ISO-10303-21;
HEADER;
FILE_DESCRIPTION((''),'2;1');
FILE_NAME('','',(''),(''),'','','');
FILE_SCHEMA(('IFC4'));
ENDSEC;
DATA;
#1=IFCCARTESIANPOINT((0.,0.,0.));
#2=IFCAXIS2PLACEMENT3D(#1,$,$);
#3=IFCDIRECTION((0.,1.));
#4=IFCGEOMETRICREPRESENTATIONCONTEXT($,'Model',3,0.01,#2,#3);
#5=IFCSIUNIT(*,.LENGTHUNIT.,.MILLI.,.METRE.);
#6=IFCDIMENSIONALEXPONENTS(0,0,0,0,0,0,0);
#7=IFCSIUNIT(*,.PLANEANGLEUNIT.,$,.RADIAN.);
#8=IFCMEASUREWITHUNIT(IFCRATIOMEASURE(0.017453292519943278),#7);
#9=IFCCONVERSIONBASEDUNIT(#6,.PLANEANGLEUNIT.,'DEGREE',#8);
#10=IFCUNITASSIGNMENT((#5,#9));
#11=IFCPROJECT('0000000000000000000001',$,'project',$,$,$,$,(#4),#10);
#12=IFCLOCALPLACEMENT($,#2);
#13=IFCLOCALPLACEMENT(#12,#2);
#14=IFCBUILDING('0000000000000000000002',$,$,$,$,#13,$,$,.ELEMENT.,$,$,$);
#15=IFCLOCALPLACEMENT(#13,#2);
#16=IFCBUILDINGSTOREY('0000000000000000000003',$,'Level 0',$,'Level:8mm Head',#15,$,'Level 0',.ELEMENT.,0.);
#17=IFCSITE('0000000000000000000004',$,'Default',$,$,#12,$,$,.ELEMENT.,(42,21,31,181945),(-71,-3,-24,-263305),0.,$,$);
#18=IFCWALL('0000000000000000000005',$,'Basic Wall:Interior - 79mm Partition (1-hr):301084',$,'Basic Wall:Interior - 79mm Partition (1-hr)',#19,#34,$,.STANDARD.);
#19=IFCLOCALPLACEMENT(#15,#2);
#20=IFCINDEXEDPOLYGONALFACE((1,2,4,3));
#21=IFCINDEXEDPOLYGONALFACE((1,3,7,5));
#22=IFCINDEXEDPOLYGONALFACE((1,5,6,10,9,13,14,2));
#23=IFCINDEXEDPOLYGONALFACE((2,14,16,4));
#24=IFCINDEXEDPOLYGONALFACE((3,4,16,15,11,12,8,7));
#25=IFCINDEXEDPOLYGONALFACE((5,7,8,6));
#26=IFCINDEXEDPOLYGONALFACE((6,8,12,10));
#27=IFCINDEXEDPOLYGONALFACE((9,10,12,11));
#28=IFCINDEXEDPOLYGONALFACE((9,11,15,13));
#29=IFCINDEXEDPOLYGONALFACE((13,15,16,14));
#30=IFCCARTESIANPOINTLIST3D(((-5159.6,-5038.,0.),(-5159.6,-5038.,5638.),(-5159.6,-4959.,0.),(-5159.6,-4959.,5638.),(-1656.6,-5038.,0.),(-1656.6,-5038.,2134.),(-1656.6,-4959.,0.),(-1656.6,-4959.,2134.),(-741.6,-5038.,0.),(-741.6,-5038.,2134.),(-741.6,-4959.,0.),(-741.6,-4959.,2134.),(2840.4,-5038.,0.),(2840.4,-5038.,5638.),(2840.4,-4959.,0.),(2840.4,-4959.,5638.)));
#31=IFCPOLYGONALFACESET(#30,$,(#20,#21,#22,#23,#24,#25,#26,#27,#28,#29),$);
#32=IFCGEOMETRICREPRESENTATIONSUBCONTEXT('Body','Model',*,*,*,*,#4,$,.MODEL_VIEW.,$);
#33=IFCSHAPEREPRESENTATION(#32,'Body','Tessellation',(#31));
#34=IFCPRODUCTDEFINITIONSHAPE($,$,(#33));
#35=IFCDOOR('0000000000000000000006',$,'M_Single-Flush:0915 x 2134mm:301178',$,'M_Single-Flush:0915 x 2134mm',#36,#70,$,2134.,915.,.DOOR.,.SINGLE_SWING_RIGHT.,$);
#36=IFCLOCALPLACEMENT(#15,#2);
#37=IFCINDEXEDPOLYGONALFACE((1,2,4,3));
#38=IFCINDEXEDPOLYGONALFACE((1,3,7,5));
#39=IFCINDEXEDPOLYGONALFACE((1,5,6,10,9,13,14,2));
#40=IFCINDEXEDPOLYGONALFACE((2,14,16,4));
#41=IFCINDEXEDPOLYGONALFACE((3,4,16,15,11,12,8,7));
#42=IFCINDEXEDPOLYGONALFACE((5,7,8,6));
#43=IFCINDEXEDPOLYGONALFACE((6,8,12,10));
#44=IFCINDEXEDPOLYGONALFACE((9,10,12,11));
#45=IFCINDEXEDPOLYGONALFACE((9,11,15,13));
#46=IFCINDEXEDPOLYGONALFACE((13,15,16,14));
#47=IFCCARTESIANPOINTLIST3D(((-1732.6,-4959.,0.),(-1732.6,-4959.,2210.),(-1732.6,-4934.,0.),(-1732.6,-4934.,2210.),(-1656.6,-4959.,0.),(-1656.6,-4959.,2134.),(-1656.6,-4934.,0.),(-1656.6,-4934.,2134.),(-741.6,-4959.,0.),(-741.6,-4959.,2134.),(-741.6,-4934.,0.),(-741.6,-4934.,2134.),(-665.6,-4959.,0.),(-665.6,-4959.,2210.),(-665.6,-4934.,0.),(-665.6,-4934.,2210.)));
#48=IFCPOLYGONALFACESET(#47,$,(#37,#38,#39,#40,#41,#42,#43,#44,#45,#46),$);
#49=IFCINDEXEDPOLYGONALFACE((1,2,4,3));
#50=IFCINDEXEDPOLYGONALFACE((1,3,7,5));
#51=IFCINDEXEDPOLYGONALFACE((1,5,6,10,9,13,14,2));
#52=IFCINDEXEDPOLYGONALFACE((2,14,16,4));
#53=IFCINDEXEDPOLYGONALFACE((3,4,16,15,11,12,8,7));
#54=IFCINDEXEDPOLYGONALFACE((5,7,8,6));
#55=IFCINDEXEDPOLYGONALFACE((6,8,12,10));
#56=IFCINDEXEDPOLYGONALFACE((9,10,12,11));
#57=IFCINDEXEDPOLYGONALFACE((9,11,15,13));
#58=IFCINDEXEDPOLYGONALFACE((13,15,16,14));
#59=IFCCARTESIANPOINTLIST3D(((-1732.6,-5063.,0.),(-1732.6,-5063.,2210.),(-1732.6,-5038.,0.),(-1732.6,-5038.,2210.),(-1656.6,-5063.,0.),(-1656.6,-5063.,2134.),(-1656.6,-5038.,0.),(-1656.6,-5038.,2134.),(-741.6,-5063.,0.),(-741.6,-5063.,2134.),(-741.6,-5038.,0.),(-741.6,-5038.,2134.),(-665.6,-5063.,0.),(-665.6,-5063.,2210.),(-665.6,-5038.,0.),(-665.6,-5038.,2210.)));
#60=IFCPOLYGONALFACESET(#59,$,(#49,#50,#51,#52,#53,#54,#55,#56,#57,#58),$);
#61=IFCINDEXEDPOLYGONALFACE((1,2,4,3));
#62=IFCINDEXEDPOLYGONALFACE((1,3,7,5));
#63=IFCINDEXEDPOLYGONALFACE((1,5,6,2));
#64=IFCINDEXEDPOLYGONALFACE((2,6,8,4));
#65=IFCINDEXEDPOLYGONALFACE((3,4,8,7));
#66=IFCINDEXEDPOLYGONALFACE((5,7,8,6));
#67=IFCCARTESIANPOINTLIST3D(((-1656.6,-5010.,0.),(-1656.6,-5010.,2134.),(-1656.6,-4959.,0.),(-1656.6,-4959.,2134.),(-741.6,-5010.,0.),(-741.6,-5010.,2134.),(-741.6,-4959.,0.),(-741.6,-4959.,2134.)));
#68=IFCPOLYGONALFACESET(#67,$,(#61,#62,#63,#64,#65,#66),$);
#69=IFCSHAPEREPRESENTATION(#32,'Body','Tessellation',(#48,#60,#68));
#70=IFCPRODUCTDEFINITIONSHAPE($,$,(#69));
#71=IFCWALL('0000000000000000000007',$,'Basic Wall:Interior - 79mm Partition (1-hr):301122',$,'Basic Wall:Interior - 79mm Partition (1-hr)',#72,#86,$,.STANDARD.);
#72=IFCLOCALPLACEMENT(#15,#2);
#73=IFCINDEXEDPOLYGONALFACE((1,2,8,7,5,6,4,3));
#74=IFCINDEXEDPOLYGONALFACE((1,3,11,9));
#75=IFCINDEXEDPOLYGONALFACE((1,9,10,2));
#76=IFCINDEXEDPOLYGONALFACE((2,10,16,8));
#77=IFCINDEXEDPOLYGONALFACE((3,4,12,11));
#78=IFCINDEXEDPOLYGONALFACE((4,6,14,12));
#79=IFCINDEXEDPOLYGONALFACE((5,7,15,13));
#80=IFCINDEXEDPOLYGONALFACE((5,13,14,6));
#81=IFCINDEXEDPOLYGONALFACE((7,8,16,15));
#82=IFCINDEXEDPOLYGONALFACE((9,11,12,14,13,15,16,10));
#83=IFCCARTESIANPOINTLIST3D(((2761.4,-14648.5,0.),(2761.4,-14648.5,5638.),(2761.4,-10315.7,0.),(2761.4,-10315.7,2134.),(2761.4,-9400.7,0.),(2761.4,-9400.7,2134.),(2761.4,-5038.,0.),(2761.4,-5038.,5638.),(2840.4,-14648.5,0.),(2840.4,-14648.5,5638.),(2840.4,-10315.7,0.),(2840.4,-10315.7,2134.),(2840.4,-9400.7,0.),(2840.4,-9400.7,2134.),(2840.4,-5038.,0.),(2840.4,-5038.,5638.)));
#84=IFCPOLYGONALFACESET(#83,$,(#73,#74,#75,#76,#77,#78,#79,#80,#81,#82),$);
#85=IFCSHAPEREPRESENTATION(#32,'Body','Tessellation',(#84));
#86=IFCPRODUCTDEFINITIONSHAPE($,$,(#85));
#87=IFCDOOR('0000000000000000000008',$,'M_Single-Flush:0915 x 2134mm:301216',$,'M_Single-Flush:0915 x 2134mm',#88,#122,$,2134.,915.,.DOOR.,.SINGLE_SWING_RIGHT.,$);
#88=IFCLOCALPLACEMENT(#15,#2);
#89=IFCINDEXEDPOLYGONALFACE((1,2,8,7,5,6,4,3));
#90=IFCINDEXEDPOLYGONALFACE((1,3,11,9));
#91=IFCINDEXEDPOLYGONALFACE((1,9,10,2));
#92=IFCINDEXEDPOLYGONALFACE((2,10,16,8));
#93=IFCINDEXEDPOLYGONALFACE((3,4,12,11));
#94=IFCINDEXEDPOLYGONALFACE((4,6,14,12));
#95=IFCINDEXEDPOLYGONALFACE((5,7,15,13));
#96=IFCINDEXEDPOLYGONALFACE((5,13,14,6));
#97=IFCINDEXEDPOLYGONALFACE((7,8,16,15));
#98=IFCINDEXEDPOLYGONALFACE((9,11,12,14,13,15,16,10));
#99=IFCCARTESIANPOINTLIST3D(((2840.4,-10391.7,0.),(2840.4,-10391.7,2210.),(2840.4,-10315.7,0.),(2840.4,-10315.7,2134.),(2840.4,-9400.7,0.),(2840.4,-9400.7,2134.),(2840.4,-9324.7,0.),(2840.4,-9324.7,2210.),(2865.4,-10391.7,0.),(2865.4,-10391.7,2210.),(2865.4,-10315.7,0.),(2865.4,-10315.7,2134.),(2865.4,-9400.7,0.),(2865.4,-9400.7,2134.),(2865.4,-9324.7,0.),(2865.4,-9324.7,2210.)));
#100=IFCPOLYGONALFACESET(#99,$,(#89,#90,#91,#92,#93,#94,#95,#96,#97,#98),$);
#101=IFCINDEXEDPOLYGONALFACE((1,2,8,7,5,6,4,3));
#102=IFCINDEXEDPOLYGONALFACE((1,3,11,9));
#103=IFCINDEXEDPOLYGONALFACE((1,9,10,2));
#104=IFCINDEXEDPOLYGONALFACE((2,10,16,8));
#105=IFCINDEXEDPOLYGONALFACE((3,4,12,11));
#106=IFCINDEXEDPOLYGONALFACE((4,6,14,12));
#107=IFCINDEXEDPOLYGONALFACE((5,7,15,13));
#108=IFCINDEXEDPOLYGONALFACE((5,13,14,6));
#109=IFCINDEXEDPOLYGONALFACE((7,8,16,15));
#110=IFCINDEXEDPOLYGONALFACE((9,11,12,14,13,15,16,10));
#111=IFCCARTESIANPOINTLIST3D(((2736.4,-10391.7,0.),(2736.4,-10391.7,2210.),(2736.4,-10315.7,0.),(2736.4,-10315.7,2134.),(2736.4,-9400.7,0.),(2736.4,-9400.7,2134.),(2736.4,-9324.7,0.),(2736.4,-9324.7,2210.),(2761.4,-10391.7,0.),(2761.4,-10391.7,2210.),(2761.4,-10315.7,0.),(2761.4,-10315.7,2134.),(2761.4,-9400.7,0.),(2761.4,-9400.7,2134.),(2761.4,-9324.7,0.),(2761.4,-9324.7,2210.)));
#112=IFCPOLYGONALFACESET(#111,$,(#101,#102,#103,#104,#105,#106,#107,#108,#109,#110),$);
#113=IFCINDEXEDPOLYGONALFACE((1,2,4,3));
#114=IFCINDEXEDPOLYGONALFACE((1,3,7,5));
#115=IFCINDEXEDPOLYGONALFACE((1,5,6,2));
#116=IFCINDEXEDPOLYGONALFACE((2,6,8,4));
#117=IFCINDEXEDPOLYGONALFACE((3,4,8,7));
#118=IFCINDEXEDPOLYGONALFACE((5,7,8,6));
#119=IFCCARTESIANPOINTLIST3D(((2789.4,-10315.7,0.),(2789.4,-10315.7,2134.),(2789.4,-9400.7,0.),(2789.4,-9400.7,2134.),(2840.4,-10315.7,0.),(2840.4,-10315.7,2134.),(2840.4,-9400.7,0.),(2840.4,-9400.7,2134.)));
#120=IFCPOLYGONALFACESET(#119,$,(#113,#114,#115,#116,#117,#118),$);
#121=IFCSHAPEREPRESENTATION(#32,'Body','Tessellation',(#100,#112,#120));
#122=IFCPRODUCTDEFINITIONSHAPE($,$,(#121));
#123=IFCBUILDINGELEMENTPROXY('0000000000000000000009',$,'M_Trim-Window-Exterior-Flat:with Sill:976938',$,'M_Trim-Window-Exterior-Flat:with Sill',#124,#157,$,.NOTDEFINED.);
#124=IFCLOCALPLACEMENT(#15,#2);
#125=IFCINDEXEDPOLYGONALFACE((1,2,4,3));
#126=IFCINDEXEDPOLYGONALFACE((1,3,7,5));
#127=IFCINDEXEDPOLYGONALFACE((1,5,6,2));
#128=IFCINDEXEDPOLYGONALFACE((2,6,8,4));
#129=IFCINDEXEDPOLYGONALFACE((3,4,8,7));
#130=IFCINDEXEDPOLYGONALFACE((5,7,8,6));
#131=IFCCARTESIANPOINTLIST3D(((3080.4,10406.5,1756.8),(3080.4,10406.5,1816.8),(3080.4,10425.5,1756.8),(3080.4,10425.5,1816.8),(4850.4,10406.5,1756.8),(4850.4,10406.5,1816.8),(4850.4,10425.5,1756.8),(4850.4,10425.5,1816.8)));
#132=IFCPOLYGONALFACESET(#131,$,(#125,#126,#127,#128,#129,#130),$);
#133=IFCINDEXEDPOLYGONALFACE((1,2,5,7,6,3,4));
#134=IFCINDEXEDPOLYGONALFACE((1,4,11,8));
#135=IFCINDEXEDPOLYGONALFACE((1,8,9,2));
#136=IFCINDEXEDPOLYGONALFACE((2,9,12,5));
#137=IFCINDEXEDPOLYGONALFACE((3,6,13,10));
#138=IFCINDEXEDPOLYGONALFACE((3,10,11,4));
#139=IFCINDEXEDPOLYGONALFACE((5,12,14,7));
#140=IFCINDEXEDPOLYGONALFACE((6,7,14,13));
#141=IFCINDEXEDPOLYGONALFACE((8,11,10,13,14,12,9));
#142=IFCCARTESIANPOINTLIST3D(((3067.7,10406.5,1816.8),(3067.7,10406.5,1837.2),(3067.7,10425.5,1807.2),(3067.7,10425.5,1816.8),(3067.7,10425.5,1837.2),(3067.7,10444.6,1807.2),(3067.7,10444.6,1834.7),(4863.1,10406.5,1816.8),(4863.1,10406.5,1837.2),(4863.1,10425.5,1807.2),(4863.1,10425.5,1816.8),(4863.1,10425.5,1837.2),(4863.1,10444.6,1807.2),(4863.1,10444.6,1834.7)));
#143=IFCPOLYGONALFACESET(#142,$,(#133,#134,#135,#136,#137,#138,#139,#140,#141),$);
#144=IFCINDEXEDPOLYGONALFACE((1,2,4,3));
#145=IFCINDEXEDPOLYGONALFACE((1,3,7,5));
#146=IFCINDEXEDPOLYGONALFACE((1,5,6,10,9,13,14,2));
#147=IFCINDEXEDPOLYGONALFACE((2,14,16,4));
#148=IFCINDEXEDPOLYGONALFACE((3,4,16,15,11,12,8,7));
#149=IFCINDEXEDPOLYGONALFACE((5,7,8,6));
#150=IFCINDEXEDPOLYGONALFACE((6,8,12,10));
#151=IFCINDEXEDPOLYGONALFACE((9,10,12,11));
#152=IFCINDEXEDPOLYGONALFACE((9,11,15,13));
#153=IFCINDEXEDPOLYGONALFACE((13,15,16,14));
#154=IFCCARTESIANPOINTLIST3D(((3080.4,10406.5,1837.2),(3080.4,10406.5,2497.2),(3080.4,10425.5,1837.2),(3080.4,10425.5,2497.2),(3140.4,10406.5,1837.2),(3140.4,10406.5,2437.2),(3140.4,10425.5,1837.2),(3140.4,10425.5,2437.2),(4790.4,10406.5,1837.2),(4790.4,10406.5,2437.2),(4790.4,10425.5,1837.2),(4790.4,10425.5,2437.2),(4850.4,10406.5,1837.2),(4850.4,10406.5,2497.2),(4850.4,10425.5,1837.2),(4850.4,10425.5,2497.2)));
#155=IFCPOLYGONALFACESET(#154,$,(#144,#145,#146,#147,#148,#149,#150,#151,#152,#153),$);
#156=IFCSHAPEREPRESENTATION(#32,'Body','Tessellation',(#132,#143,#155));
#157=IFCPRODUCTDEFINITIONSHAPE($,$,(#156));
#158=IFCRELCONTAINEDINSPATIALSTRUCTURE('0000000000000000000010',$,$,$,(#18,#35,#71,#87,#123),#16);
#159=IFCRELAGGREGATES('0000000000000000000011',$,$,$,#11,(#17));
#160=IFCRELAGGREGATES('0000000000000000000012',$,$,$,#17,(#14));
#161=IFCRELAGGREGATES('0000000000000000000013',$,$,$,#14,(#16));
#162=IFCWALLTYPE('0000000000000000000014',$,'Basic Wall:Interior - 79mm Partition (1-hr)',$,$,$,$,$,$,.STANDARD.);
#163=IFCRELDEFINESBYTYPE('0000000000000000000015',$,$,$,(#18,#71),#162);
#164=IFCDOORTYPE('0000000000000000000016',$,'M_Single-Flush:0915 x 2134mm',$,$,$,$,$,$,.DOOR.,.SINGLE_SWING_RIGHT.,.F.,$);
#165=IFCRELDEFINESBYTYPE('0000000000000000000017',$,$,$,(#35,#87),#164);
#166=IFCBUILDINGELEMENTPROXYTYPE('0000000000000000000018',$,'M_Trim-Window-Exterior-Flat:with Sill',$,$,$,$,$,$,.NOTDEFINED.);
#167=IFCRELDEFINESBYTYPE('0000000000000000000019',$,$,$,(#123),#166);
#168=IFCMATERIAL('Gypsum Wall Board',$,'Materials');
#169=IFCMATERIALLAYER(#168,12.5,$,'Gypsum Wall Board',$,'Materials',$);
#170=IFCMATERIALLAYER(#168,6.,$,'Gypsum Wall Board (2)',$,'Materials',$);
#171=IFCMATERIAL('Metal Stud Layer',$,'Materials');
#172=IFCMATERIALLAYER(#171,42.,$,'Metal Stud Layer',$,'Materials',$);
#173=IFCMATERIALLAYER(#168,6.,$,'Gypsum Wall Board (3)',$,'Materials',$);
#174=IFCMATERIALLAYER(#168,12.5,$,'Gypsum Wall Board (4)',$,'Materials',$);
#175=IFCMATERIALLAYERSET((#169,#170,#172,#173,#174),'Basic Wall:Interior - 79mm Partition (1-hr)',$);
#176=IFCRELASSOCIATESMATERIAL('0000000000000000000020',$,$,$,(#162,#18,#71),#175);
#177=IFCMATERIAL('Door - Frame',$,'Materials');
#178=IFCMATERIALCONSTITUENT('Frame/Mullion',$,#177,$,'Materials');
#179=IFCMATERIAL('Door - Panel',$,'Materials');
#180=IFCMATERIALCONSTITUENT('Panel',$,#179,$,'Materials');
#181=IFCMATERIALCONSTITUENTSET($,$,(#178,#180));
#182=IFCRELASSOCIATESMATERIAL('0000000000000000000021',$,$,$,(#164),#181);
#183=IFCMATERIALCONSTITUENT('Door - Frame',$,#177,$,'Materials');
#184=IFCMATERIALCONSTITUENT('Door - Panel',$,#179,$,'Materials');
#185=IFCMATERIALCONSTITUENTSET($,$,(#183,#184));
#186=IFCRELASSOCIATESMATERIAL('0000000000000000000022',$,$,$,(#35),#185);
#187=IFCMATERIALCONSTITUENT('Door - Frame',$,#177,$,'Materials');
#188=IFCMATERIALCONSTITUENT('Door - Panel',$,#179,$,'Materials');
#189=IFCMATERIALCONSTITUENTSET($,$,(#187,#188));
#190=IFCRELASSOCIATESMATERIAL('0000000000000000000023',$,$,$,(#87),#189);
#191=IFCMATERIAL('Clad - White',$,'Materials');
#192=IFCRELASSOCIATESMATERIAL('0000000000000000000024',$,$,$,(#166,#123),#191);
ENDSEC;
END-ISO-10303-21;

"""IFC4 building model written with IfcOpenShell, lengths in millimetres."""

from ifc_helpers import new_model, entity, si_unit, converted_unit, direction, frame, frame_2d, origin, origin_2d_with_axis, place, context, subcontext, project, spatial, polyline, rectangle, outline, extrude, clip, bounded_halfspace, source, transform, mapped, material, layer, layer_set, layer_usage, constituent, constituent_set, type_object, type_shapes, element, fill, save


model = new_model("IFC4")

# Units and contexts
model_context = context("Model", 3, precision=0.01, world=origin(), true_north=direction((0.0, 1.0)))
body_context = subcontext(model_context, "Body", "Model", "MODEL_VIEW")
ifc_project = project(units=[si_unit("LENGTHUNIT", "METRE", prefix="MILLI"), converted_unit("PLANEANGLEUNIT", "DEGREE", entity("IfcRatioMeasure", 0.017453292519943278), si_unit("PLANEANGLEUNIT", "RADIAN"), dimensions=[0, 0, 0, 0, 0, 0, 0])], contexts=[model_context])

# Site, building, storey
site_placement = place(None, origin())
site = spatial("IfcSite", under=ifc_project, at=site_placement, Name="Default", CompositionType="ELEMENT", RefLatitude=(42, 21, 31, 181945), RefLongitude=(-71, -3, -24, -263305), RefElevation=0.0)
building_placement = place(site_placement, origin())
building = spatial("IfcBuilding", under=site, at=building_placement, CompositionType="ELEMENT")
storey_placement = place(building_placement, origin())
storey = spatial("IfcBuildingStorey", under=building, at=storey_placement, Name="Level 0", ObjectType="Level:8mm Head", LongName="Level 0", CompositionType="ELEMENT", Elevation=0.0)

# Shared definitions
ifc_material_1 = material(Name="Metal Stud Layer", Category="Materials")
ifc_material_2 = material(Name="Gypsum Wall Board", Category="Materials")

# Shared definitions
ifc_material_3 = material(Name="Door - Frame", Category="Materials")
ifc_material_4 = material(Name="Door - Panel", Category="Materials")

# Walls, openings, doors
ifc_layer_1 = layer(ifc_material_2, 12.5, Name="Gypsum Wall Board", Category="Materials")
ifc_layer_2 = layer(ifc_material_2, 6.0, Name="Gypsum Wall Board (2)", Category="Materials")
ifc_layer_3 = layer(ifc_material_1, 42.0, Name="Metal Stud Layer", Category="Materials")
ifc_layer_4 = layer(ifc_material_2, 6.0, Name="Gypsum Wall Board (3)", Category="Materials")
ifc_layer_5 = layer(ifc_material_2, 12.5, Name="Gypsum Wall Board (4)", Category="Materials")
ifc_layer_set_1 = layer_set([ifc_layer_1, ifc_layer_2, ifc_layer_3, ifc_layer_4, ifc_layer_5], Name="Basic Wall:Interior - 79mm Partition (1-hr)")
ifc_layer_usage_1 = layer_usage(ifc_layer_set_1, "AXIS2", "NEGATIVE", 39.5)
wall_type_1 = type_object("IfcWallType", Name="Basic Wall:Interior - 79mm Partition (1-hr)", PredefinedType="STANDARD", material=ifc_layer_set_1)
wall_1_placement = place(storey_placement, frame((-5159.6, -4998.5, 0.0)))
wall_1 = element("IfcWall", 1, at=wall_1_placement, inside=storey, type_object=wall_type_1, material=ifc_layer_usage_1, Name="Basic Wall:Interior - 79mm Partition (1-hr):301084", ObjectType="Basic Wall:Interior - 79mm Partition (1-hr)", PredefinedType="STANDARD", context=body_context, shape_type="Clipping", body=[
    clip(extrude(rectangle(XDim=8000.0, YDim=79.0, at=frame_2d((4000.0, 0.0), x_axis=(1.0, 0.0))), origin(), (0.0, 0.0, 1.0), 5638.0), bounded_halfspace(frame((0.0, -39.5, 5638.0), z_axis=(0.0, 0.0, -1.0), x_axis=(0.0, -1.0, 0.0)), True, frame((0.0, -39.5, 5638.0)), polyline([(0.0, 0.0), (2414320.8, 0.0), (2438400.0, 0.0), (2438400.0, 24079.2), (0.0, 24079.2), (0.0, 0.0)]))),
])
opening_1_placement = place(wall_1_placement, frame((3503.0, -39.5, 0.0)))
opening_1 = element("IfcOpeningElement", 2, at=opening_1_placement, cuts=wall_1, PredefinedType="OPENING", context=body_context, shape_type="SweptSolid", body=[
    extrude(rectangle(XDim=915.0, YDim=2134.0, at=frame_2d((1067.0, 457.5), x_axis=(0.0, 1.0))), frame((0.0, 0.0, 0.0), z_axis=(0.0, 1.0, 0.0), x_axis=(0.0, 0.0, 1.0)), (0.0, 0.0, 1.0), 79.0),
])
ifc_constituent_1 = constituent(ifc_material_3, Name="Door - Frame", Category="Materials")
ifc_constituent_2 = constituent(ifc_material_4, Name="Door - Panel", Category="Materials")
ifc_constituent_set_1 = constituent_set(constituents=[ifc_constituent_1, ifc_constituent_2])
ifc_constituent_3 = constituent(ifc_material_3, Name="Frame/Mullion", Category="Materials")
ifc_constituent_4 = constituent(ifc_material_4, Name="Panel", Category="Materials")
ifc_constituent_set_2 = constituent_set(constituents=[ifc_constituent_3, ifc_constituent_4])
door_type_1 = type_object("IfcDoorType", Name="M_Single-Flush:0915 x 2134mm", OperationType="SINGLE_SWING_RIGHT", ParameterTakesPrecedence=False, PredefinedType="DOOR", material=ifc_constituent_set_2)
shared_shape_1 = source(origin(), body_context, "Body", "SweptSolid", [
    extrude(outline(polyline([(-533.5, -1124.0), (533.5, -1124.0), (533.5, 1086.0), (457.5, 1086.0), (457.5, -1048.0), (-457.5, -1048.0), (-457.5, 1086.0), (-533.5, 1086.0), (-533.5, -1124.0)])), frame((457.5, 79.0, 1086.0), z_axis=(0.0, 1.0, 0.0), x_axis=(1.0, 0.0, 0.0)), (0.0, 0.0, 1.0), 25.0),
    extrude(outline(polyline([(-1124.0, -533.5), (1086.0, -533.5), (1086.0, -457.5), (-1048.0, -457.5), (-1048.0, 457.5), (1086.0, 457.5), (1086.0, 533.5), (-1124.0, 533.5), (-1124.0, -533.5)])), frame((457.5, -25.0, 1086.0), z_axis=(0.0, 1.0, 0.0), x_axis=(0.0, 0.0, -1.0)), (0.0, 0.0, 1.0), 25.0),
    extrude(rectangle(XDim=51.0, YDim=915.0, at=origin_2d_with_axis()), frame((457.5, 53.5, 0.0), z_axis=(0.0, 0.0, 1.0), x_axis=(0.0, 1.0, 0.0)), (0.0, 0.0, 1.0), 2134.0),
])
type_shapes(door_type_1, [shared_shape_1])
door_1_placement = place(opening_1_placement, origin())
door_1 = element("IfcDoor", 3, at=door_1_placement, inside=storey, type_object=door_type_1, material=ifc_constituent_set_1, Name="M_Single-Flush:0915 x 2134mm:301178", ObjectType="M_Single-Flush:0915 x 2134mm", OperationType="SINGLE_SWING_RIGHT", OverallHeight=2134.0, OverallWidth=915.0, PredefinedType="DOOR", context=body_context, shape_type="MappedRepresentation", body=[
    mapped(shared_shape_1, transform((0.0, 0.0, 0.0), scale=1.0)),
])
fill(opening_1, door_1)
wall_2_placement = place(storey_placement, frame((2800.9, -5038.0, 0.0), z_axis=(0.0, 0.0, 1.0), x_axis=(0.0, -1.0, 0.0)))
wall_2 = element("IfcWall", 4, at=wall_2_placement, inside=storey, type_object=wall_type_1, material=ifc_layer_usage_1, Name="Basic Wall:Interior - 79mm Partition (1-hr):301122", ObjectType="Basic Wall:Interior - 79mm Partition (1-hr)", PredefinedType="STANDARD", context=body_context, shape_type="Clipping", body=[
    clip(extrude(rectangle(XDim=9610.5, YDim=79.0, at=frame_2d((4805.3, 0.0), x_axis=(-1.0, 0.0))), origin(), (0.0, 0.0, 1.0), 5638.0), bounded_halfspace(frame((0.0, -39.5, 5638.0), z_axis=(0.0, 0.0, -1.0), x_axis=(1.0, 0.0, 0.0)), True, frame((0.0, -39.5, 5638.0)), polyline([(0.0, 0.0), (2929280.4, 0.0), (2929280.4, 24079.2), (0.0, 24079.2), (0.0, 0.0)]))),
])
opening_2_placement = place(wall_2_placement, frame((4362.6, -39.5, 0.0)))
opening_2 = element("IfcOpeningElement", 5, at=opening_2_placement, cuts=wall_2, PredefinedType="OPENING", context=body_context, shape_type="SweptSolid", body=[
    extrude(rectangle(XDim=915.0, YDim=2134.0, at=frame_2d((1067.0, 457.5), x_axis=(0.0, 1.0))), frame((0.0, 0.0, 0.0), z_axis=(0.0, 1.0, 0.0), x_axis=(0.0, 0.0, 1.0)), (0.0, 0.0, 1.0), 79.0),
])
ifc_constituent_5 = constituent(ifc_material_3, Name="Door - Frame", Category="Materials")
ifc_constituent_6 = constituent(ifc_material_4, Name="Door - Panel", Category="Materials")
ifc_constituent_set_3 = constituent_set(constituents=[ifc_constituent_5, ifc_constituent_6])
door_2_placement = place(opening_2_placement, origin())
door_2 = element("IfcDoor", 6, at=door_2_placement, inside=storey, type_object=door_type_1, material=ifc_constituent_set_3, Name="M_Single-Flush:0915 x 2134mm:301216", ObjectType="M_Single-Flush:0915 x 2134mm", OperationType="SINGLE_SWING_RIGHT", OverallHeight=2134.0, OverallWidth=915.0, PredefinedType="DOOR", context=body_context, shape_type="MappedRepresentation", body=[
    mapped(shared_shape_1, transform((0.0, 0.0, 0.0), scale=1.0)),
])
fill(opening_2, door_2)

# Building element proxy
ifc_material_5 = material(Name="Clad - White", Category="Materials")
building_element_proxy_type_1 = type_object("IfcBuildingElementProxyType", Name="M_Trim-Window-Exterior-Flat:with Sill", PredefinedType="NOTDEFINED", material=ifc_material_5)
shared_shape_2 = source(origin(), body_context, "Body", "SweptSolid", [
    extrude(rectangle(XDim=1770.0, YDim=60.0, at=frame_2d((0.0, 0.0), x_axis=(1.0, 0.0))), frame((0.0, -650.4, 0.0), z_axis=(0.0, 0.0, 1.0), x_axis=(-1.0, 0.0, 0.0)), (0.0, 0.0, 1.0), 19.0),
    extrude(outline(polyline([(-19.0, -15.2), (0.0, -15.2), (0.0, -5.7), (19.0, -5.7), (19.0, 14.8), (0.0, 14.8), (-19.0, 12.3), (-19.0, -15.2)])), frame((-897.7, -614.8, 19.0), z_axis=(1.0, 0.0, 0.0), x_axis=(0.0, 0.0, -1.0)), (0.0, 0.0, 1.0), 1795.4),
    extrude(outline(polyline([(-345.0, -885.0), (315.0, -885.0), (315.0, -825.0), (-285.0, -825.0), (-285.0, 825.0), (315.0, 825.0), (315.0, 885.0), (-345.0, 885.0), (-345.0, -885.0)])), frame((0.0, -285.0, 0.0), z_axis=(0.0, 0.0, 1.0), x_axis=(0.0, -1.0, 0.0)), (0.0, 0.0, 1.0), 19.0),
])
type_shapes(building_element_proxy_type_1, [shared_shape_2])
for number, where, z_axis, x_axis, name in (
    (7, (3965.4, 10406.5, 2437.2), (0.0, 1.0, 0.0), (-1.0, 0.0, 0.0), "M_Trim-Window-Exterior-Flat:with Sill:976938"),
):
    element("IfcBuildingElementProxy", number, at=place(storey_placement, frame(where, z_axis=z_axis, x_axis=x_axis)), inside=storey, type_object=building_element_proxy_type_1, material=ifc_material_5, Name=name, ObjectType="M_Trim-Window-Exterior-Flat:with Sill", PredefinedType="NOTDEFINED", context=body_context, shape_type="MappedRepresentation", body=[
        mapped(shared_shape_2, transform((0.0, 0.0, 0.0), scale=1.0)),
    ])

save(model, "model.ifc")
